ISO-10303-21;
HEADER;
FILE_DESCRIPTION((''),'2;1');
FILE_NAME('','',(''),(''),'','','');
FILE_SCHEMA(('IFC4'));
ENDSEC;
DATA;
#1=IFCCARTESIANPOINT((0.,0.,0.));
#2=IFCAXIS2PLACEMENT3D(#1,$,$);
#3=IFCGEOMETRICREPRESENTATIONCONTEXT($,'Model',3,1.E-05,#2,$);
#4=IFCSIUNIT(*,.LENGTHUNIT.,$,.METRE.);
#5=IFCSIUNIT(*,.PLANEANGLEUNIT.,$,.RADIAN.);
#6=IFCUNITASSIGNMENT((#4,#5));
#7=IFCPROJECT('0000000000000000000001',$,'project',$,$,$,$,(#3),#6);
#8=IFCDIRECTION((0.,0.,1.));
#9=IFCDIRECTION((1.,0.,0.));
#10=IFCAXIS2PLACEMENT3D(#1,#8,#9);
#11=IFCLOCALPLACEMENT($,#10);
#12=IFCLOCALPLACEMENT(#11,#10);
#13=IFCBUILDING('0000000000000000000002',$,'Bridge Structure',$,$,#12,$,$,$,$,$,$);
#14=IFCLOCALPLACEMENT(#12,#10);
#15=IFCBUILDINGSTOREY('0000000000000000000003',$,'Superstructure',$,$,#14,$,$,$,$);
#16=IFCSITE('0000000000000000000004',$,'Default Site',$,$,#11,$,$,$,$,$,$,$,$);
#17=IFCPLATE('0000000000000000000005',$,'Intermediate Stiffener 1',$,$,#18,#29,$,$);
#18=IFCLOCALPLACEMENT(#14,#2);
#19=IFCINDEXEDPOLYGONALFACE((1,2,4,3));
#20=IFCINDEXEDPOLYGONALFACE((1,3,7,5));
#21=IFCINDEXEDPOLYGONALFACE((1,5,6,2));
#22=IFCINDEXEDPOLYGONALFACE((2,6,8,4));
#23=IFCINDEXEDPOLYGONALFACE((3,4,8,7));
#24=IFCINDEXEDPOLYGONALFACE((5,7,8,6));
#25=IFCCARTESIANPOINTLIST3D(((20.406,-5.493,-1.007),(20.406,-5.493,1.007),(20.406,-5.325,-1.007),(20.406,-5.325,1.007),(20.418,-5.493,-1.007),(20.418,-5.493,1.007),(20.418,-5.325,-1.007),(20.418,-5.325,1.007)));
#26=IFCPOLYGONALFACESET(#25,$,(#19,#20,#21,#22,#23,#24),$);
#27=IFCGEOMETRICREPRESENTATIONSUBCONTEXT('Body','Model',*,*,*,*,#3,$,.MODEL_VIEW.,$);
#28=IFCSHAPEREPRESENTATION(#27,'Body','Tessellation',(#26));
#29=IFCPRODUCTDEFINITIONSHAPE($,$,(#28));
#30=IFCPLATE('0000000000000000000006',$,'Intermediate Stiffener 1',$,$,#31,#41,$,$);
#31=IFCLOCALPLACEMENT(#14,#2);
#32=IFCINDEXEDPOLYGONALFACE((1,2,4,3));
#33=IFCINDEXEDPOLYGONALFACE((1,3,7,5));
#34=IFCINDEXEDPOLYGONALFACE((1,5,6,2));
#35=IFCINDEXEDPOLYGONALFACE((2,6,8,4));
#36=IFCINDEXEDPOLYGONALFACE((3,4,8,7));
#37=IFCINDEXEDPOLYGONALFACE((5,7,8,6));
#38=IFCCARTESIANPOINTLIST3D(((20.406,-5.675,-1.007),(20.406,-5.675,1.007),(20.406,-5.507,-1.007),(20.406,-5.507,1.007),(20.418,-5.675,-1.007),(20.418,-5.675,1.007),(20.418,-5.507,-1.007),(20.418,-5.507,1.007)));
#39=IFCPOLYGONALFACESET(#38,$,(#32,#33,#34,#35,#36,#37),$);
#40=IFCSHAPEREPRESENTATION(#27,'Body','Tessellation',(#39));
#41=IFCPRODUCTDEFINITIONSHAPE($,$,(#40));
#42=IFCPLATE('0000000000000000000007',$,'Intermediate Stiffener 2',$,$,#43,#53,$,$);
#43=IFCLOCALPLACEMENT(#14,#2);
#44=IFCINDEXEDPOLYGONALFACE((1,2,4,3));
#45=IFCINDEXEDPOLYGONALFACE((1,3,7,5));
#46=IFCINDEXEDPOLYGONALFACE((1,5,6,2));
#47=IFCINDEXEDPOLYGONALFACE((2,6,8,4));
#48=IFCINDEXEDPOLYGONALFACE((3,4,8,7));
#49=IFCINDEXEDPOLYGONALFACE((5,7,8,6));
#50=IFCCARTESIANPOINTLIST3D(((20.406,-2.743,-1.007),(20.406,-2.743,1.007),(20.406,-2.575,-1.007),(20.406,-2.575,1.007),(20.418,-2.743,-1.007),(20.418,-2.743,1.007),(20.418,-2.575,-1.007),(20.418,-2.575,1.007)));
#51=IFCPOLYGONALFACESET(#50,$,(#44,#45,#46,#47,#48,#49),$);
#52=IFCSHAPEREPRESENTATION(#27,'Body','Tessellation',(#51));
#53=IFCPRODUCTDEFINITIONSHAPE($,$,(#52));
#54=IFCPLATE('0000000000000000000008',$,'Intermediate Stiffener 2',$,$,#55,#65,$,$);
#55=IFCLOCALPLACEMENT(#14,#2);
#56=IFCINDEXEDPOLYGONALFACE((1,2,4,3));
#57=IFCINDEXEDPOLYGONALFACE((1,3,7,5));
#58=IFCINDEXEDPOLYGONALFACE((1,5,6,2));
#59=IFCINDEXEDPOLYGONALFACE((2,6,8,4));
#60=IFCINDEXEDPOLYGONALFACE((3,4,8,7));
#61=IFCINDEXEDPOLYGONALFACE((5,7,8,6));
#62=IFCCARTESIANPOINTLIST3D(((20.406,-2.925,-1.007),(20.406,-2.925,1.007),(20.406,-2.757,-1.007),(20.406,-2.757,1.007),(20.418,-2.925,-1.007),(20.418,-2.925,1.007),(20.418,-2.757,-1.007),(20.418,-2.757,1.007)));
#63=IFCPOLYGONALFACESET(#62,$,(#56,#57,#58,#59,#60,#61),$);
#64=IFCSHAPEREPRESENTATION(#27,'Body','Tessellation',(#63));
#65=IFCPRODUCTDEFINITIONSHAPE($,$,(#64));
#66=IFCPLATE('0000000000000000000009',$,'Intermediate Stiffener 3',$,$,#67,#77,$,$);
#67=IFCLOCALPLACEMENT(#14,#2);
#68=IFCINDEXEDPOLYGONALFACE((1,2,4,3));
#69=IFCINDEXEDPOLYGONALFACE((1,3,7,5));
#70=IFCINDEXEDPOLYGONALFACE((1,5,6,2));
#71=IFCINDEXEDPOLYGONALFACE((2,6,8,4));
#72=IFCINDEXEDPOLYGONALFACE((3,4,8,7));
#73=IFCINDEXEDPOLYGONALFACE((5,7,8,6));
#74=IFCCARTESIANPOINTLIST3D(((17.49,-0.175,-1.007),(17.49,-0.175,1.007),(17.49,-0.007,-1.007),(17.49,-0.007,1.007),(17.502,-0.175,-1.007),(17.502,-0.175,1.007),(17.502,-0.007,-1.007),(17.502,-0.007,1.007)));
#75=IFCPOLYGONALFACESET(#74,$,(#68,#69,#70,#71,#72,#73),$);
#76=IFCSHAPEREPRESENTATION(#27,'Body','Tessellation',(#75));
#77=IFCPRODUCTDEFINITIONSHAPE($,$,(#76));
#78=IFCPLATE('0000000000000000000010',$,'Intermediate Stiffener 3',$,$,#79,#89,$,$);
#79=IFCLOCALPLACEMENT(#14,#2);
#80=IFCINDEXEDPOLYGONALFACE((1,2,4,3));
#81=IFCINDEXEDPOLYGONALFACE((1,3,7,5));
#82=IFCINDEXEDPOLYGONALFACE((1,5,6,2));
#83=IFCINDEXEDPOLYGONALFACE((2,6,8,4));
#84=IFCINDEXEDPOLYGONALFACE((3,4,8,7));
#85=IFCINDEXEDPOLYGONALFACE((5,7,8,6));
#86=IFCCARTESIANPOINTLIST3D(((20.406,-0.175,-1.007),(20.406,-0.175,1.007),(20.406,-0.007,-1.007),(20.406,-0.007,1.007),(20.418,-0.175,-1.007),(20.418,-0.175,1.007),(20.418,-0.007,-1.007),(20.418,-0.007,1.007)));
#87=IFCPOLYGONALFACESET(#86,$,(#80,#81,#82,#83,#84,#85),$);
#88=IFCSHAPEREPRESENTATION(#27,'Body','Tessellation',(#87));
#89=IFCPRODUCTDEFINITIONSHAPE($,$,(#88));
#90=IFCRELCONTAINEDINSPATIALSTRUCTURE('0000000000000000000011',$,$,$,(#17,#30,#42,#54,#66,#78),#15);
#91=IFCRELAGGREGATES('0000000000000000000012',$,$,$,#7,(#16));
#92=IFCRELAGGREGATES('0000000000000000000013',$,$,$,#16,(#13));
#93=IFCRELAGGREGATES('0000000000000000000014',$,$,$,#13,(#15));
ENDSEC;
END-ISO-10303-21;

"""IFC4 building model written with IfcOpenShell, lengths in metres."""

from ifc_helpers import new_model, si_unit, frame, origin, origin_with_axes, origin_2d_with_axis, place, context, subcontext, project, spatial, rectangle, extrude, element, save


model = new_model("IFC4")

# Units and contexts
model_context = context("Model", 3, precision=1e-05, world=origin())
body_context = subcontext(model_context, "Body", "Model", "MODEL_VIEW")
ifc_project = project(units=[si_unit("LENGTHUNIT", "METRE"), si_unit("PLANEANGLEUNIT", "RADIAN")], contexts=[model_context])

# Site, building, storey
site_placement = place(None, origin_with_axes())
site = spatial("IfcSite", under=ifc_project, at=site_placement, Name="Default Site")
building_placement = place(site_placement, origin_with_axes())
building = spatial("IfcBuilding", under=site, at=building_placement, Name="Bridge Structure")
storey_placement = place(building_placement, origin_with_axes())
storey = spatial("IfcBuildingStorey", under=building, at=storey_placement, Name="Superstructure")

# Plates
for number, where, z_axis, x_axis, name in (
    (1, (20.412, -5.409, -1.007), (0.0, 0.0, 1.0), (1.0, 0.0, 0.0), "Intermediate Stiffener 1"),
    (2, (20.412, -5.591, -1.007), (0.0, 0.0, 1.0), (1.0, 0.0, 0.0), "Intermediate Stiffener 1"),
    (3, (20.412, -2.659, -1.007), (0.0, 0.0, 1.0), (1.0, 0.0, 0.0), "Intermediate Stiffener 2"),
    (4, (20.412, -2.841, -1.007), (0.0, 0.0, 1.0), (1.0, 0.0, 0.0), "Intermediate Stiffener 2"),
    (5, (17.496, -0.091, -1.007), (0.0, 0.0, 1.0), (1.0, 0.0, 0.0), "Intermediate Stiffener 3"),
    (6, (20.412, -0.091, -1.007), (0.0, 0.0, 1.0), (1.0, 0.0, 0.0), "Intermediate Stiffener 3"),
):
    element("IfcPlate", number, at=place(storey_placement, frame(where, z_axis=z_axis, x_axis=x_axis)), inside=storey, Name=name, context=body_context, shape_type="SweptSolid", body=[
        extrude(rectangle(XDim=0.012, YDim=0.168, at=origin_2d_with_axis()), origin_with_axes(), (0.0, 0.0, 1.0), 2.014),
    ])

save(model, "model.ifc")
